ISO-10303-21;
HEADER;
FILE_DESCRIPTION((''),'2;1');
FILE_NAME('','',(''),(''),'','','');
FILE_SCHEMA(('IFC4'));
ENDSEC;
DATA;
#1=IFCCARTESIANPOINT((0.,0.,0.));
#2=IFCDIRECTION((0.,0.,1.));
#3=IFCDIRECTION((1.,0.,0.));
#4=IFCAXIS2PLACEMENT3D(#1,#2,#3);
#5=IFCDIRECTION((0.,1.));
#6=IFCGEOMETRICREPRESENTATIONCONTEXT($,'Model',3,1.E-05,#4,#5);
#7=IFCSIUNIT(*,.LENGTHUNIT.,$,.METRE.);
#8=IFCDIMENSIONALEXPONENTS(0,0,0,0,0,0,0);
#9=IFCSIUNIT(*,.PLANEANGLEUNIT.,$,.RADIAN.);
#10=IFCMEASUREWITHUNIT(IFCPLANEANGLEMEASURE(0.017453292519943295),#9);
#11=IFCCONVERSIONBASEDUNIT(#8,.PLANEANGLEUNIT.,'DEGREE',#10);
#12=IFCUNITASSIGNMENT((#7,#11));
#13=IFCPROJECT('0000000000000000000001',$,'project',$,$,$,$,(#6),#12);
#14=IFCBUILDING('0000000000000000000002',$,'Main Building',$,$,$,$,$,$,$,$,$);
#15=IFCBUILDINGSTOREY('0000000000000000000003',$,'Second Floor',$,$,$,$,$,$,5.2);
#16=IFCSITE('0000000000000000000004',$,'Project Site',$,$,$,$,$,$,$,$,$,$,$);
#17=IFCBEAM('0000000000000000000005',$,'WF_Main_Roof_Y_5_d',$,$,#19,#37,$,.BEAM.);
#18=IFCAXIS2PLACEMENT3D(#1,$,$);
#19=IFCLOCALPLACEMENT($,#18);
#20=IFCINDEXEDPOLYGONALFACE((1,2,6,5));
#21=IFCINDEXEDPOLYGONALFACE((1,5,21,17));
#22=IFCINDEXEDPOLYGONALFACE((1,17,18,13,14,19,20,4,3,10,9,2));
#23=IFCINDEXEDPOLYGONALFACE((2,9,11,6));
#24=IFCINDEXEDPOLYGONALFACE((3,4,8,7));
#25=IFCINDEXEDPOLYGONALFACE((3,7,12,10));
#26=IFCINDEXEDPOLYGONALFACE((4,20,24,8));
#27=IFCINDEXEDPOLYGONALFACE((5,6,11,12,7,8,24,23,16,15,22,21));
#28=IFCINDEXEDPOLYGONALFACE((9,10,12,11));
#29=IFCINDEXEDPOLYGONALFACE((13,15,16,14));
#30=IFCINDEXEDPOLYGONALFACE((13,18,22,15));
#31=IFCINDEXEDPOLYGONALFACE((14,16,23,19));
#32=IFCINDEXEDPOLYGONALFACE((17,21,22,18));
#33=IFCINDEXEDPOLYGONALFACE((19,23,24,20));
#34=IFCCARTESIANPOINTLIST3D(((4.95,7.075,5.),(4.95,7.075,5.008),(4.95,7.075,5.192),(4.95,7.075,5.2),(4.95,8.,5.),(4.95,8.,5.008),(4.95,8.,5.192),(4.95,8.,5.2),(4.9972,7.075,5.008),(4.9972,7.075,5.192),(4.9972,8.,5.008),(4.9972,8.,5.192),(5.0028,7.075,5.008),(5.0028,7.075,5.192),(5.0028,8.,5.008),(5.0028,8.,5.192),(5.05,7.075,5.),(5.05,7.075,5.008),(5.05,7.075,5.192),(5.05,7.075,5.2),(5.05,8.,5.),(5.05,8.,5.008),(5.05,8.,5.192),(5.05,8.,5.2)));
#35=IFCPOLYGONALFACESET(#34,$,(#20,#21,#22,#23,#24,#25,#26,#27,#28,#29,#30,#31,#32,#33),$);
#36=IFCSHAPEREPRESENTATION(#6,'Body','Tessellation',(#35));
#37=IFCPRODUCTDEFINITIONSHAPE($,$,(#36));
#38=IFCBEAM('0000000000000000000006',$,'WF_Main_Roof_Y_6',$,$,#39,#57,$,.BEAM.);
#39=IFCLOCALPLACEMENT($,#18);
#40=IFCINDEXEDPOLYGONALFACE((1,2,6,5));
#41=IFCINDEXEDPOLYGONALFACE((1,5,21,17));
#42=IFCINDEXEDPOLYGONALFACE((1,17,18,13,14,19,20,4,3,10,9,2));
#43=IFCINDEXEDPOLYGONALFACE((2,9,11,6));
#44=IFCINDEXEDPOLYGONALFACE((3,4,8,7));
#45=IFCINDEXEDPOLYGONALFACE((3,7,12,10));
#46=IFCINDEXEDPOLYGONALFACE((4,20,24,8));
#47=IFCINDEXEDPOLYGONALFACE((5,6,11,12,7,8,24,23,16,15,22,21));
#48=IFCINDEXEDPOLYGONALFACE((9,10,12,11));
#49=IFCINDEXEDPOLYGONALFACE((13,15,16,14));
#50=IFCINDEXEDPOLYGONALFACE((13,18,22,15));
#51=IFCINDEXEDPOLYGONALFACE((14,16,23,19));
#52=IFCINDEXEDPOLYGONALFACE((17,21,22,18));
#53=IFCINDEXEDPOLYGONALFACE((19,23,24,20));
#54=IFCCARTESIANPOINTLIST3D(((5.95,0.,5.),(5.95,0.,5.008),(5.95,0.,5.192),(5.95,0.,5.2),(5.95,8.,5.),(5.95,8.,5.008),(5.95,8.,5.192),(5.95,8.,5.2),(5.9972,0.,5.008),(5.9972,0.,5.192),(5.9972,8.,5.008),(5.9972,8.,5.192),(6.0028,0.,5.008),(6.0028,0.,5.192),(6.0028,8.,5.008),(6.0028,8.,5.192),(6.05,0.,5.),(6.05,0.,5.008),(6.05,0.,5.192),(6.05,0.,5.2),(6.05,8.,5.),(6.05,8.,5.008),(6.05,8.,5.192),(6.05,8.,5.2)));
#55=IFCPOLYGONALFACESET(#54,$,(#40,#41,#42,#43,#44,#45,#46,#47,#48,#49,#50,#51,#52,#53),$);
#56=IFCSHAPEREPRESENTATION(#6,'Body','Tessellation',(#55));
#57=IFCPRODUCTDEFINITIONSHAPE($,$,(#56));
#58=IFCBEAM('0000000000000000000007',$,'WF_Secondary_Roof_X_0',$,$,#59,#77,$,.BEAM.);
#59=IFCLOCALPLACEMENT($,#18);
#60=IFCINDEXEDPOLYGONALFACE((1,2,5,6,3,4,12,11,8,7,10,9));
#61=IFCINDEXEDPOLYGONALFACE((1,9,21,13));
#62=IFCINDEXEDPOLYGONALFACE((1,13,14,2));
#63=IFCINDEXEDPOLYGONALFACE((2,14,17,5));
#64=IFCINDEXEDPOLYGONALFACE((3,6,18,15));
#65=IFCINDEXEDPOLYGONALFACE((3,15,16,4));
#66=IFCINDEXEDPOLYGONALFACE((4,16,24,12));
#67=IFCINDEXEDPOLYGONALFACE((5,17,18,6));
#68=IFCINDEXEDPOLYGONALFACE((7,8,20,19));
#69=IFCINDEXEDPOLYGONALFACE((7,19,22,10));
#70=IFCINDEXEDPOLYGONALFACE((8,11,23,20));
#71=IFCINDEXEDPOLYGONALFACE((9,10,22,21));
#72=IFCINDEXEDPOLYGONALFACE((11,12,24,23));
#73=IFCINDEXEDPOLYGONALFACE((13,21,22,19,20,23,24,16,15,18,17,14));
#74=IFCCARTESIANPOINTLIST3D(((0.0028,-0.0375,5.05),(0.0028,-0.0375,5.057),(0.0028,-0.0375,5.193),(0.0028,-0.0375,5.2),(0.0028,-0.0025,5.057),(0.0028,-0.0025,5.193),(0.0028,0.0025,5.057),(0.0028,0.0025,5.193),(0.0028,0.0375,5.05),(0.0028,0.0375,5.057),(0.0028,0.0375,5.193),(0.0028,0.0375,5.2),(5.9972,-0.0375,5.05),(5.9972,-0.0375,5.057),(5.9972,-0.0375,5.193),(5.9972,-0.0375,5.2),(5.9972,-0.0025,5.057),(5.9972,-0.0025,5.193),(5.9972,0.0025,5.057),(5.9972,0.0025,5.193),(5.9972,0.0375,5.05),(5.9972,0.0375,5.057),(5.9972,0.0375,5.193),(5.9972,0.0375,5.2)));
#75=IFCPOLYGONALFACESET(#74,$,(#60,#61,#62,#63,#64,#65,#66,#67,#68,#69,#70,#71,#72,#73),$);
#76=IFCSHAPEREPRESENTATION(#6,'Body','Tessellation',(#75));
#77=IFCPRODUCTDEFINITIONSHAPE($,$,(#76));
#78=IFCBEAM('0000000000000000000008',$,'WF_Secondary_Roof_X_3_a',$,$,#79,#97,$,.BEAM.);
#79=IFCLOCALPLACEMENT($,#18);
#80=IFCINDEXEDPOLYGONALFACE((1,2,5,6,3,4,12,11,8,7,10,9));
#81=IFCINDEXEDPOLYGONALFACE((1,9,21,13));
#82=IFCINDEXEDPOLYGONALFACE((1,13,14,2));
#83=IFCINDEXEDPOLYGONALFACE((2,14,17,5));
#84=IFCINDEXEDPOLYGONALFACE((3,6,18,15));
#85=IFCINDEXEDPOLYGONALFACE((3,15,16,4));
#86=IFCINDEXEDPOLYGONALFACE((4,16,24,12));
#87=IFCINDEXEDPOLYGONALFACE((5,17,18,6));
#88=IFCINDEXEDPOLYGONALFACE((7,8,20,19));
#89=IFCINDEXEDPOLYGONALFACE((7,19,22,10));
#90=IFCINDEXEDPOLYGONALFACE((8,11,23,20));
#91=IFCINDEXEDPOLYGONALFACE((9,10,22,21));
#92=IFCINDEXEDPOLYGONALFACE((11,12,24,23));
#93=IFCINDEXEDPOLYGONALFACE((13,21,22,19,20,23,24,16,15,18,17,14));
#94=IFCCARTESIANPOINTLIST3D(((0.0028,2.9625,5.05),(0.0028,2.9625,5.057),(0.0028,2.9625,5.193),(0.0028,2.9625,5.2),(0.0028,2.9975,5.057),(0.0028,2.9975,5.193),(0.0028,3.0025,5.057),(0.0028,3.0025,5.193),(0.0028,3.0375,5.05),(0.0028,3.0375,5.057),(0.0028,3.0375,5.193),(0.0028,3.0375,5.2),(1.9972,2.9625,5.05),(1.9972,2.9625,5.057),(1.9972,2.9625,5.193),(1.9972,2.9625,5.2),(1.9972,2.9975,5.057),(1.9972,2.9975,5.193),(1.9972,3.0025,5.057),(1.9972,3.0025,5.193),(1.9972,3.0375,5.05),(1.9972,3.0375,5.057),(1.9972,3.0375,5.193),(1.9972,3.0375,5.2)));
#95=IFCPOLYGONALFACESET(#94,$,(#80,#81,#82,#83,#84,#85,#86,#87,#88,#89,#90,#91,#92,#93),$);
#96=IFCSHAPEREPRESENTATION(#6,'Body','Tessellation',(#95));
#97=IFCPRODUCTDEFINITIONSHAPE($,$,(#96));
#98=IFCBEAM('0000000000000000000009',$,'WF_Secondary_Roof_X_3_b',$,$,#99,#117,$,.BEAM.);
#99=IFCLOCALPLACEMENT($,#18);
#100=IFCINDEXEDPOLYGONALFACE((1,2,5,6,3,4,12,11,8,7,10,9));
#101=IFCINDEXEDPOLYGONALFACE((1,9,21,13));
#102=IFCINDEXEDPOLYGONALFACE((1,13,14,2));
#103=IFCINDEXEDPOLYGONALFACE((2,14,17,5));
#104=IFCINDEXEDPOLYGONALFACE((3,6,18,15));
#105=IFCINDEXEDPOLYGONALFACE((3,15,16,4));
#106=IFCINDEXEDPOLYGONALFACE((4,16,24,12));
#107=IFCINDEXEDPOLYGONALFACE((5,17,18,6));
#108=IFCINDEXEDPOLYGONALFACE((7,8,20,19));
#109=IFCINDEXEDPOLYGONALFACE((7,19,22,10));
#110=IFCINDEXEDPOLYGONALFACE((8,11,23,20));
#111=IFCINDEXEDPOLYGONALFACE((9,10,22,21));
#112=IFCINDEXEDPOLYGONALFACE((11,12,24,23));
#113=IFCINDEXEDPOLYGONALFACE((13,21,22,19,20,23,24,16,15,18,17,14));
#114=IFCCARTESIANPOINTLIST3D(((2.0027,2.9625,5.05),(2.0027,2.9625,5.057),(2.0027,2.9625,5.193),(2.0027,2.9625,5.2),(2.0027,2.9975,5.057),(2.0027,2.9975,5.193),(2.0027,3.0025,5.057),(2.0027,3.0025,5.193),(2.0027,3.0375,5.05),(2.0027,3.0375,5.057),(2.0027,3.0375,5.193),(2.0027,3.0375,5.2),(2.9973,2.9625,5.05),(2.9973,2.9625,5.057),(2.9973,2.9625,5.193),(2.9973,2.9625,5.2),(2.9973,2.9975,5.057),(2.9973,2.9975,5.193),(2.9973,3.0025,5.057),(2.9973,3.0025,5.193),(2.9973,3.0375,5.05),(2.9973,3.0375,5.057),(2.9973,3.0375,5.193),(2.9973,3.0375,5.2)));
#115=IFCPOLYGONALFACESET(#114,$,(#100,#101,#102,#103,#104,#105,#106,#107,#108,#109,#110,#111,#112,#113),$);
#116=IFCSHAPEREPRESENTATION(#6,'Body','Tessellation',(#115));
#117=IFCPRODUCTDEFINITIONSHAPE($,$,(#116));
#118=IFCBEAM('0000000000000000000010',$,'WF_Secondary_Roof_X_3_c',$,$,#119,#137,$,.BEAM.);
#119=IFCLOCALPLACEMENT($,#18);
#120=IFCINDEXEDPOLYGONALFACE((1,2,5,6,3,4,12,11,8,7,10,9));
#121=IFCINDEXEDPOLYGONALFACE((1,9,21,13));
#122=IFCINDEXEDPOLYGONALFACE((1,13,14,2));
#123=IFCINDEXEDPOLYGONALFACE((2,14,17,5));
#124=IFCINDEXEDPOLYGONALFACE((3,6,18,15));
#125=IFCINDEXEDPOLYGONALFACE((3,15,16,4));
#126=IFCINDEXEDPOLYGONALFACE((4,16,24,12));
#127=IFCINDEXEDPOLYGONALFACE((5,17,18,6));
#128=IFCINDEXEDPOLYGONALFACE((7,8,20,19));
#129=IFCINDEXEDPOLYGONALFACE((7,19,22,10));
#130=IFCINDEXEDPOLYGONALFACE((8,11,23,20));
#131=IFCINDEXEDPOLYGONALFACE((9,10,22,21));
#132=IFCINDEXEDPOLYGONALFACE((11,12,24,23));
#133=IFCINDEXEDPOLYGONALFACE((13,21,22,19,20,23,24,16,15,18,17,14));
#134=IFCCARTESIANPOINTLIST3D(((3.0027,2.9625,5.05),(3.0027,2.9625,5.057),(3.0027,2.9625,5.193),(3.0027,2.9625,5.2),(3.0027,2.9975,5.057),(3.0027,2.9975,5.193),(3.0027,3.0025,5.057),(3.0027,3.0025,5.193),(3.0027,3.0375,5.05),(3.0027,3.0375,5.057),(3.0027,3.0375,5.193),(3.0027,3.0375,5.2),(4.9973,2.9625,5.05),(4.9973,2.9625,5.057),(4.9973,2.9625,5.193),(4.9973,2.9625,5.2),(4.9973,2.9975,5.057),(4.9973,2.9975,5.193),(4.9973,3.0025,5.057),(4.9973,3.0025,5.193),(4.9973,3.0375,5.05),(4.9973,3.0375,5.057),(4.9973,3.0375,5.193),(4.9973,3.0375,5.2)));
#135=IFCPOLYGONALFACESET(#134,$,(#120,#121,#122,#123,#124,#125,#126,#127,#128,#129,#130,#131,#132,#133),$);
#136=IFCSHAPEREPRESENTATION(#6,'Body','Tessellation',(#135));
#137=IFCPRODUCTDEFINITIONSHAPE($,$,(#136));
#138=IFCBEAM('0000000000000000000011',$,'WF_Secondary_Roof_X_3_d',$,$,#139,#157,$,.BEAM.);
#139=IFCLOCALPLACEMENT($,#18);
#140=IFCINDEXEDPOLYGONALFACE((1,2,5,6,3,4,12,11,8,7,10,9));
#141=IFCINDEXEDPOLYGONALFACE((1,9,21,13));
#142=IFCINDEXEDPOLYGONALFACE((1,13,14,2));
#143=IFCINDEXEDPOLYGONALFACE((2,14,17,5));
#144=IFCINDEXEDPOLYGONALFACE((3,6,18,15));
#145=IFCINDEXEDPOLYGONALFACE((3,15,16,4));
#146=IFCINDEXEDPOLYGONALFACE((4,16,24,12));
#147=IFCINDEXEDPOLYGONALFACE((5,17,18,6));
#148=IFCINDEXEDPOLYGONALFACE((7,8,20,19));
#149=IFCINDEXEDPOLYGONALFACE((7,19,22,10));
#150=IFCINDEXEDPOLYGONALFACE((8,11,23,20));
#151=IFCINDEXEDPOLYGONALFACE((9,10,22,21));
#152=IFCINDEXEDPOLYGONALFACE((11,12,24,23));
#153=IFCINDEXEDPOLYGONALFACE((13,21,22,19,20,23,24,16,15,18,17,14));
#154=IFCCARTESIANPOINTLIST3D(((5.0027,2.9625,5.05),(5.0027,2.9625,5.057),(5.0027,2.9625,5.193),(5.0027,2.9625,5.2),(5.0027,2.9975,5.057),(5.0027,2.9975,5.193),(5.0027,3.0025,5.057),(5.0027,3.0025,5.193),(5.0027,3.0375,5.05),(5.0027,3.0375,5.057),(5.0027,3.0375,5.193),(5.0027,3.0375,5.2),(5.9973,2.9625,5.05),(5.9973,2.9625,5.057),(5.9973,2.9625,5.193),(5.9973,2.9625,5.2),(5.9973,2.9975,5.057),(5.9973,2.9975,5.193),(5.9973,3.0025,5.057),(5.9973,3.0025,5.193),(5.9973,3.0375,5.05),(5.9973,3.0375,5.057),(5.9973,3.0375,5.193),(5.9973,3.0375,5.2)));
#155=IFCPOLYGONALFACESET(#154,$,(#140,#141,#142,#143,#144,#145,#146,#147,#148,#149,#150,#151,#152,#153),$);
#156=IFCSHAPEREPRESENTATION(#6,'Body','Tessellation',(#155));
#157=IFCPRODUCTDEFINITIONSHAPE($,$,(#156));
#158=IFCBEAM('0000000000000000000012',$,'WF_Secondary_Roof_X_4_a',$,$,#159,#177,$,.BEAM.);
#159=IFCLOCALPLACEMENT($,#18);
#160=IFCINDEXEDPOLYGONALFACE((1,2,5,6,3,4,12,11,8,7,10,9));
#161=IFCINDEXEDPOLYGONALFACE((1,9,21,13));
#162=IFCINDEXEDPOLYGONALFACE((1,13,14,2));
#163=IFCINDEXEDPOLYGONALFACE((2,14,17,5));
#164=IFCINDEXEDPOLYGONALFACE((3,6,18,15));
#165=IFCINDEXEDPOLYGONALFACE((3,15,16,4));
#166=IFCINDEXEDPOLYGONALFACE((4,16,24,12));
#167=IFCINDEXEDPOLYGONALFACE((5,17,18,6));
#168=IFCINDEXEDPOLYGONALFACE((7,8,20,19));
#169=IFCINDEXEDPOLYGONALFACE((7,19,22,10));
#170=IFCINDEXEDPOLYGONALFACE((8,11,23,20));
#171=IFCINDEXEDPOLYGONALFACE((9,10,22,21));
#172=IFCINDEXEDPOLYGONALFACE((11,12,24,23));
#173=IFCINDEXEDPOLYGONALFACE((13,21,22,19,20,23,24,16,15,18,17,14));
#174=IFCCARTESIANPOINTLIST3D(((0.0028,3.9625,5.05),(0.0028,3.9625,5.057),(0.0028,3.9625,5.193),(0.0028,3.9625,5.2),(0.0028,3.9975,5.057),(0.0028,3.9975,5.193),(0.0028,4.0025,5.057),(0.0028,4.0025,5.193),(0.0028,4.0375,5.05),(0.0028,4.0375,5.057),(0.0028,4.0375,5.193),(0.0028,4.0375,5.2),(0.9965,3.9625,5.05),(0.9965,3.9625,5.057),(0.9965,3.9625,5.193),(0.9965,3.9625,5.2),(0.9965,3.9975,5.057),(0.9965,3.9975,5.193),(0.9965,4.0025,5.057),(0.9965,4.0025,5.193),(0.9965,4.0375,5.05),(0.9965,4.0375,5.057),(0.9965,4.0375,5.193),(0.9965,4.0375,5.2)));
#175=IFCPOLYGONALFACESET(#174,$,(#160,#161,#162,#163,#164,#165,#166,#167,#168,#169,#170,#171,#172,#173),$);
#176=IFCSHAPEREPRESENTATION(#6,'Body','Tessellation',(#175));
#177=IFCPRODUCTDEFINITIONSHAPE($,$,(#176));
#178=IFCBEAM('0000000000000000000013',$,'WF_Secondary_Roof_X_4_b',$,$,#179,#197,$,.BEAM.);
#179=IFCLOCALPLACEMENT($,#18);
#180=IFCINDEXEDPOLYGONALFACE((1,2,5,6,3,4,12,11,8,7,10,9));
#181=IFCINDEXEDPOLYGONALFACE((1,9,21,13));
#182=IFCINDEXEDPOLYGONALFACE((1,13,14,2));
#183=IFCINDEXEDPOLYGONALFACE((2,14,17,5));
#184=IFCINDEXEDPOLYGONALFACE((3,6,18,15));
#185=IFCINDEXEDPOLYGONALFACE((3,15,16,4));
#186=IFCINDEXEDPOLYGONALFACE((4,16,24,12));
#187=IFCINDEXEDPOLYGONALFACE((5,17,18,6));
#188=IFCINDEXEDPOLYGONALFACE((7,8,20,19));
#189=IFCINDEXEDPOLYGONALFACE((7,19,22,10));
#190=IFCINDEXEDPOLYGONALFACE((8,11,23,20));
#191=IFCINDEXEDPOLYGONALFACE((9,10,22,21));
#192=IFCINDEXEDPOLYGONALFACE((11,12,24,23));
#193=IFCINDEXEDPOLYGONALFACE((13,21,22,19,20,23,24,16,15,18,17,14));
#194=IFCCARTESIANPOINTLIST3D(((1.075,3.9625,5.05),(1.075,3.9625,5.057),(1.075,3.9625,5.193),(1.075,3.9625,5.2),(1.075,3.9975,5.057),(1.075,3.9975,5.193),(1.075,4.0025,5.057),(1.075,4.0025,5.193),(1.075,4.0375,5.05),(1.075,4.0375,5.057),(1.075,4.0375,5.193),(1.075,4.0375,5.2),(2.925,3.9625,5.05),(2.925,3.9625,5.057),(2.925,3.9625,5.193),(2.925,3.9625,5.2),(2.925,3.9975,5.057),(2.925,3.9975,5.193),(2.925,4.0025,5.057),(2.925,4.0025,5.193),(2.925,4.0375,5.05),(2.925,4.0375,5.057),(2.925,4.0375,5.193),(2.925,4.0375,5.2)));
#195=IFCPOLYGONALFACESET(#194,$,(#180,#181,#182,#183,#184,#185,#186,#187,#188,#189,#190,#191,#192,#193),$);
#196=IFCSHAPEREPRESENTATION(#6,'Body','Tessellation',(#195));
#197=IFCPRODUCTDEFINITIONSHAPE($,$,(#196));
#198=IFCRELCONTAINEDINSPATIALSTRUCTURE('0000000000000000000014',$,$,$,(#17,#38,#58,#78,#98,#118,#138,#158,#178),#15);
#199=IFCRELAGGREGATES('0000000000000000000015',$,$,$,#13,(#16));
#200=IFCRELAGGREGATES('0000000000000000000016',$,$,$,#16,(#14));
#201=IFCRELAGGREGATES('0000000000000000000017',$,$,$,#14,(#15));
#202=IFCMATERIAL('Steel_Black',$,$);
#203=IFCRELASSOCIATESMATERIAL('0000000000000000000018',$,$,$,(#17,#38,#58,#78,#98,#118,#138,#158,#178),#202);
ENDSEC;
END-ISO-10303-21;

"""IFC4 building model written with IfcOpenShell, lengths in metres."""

from ifc_helpers import new_model, entity, si_unit, converted_unit, direction, frame, frame_2d, origin_with_axes, place, context, project, spatial, i_section, extrude, material, element, save


model = new_model("IFC4")

# Units and contexts
model_context = context("Model", 3, precision=1e-05, world=origin_with_axes(), true_north=direction((0.0, 1.0)))
ifc_project = project(units=[si_unit("LENGTHUNIT", "METRE"), converted_unit("PLANEANGLEUNIT", "DEGREE", entity("IfcPlaneAngleMeasure", 0.017453292519943295), si_unit("PLANEANGLEUNIT", "RADIAN"), dimensions=[0, 0, 0, 0, 0, 0, 0])], contexts=[model_context])

# Site, building, storey
site = spatial("IfcSite", under=ifc_project, Name="Project Site")
building = spatial("IfcBuilding", under=site, Name="Main Building")
storey = spatial("IfcBuildingStorey", under=building, Name="Second Floor", Elevation=5.2)

# Beams
ifc_material = material(Name="Steel_Black")
beam_1_placement = place(None, frame((5.0, 7.075, 5.0), z_axis=(0.0, 0.0, 1.0), x_axis=(0.0, 1.0, 0.0)))
element("IfcBeam", 1, at=beam_1_placement, inside=storey, material=ifc_material, Name="WF_Main_Roof_Y_5_d", PredefinedType="BEAM", context=model_context, shape_type="SweptSolid", body=[
    extrude(i_section(OverallWidth=0.1, OverallDepth=0.2, WebThickness=0.0055, FlangeThickness=0.008, at=frame_2d((0.0, 0.1))), frame((0.0, 0.0, 0.0), z_axis=(1.0, 0.0, 0.0), x_axis=(0.0, 1.0, 0.0)), (0.0, 0.0, 1.0), 0.925),
])
beam_2_placement = place(None, frame((6.0, 0.0, 5.0), z_axis=(0.0, 0.0, 1.0), x_axis=(0.0, 1.0, 0.0)))
element("IfcBeam", 2, at=beam_2_placement, inside=storey, material=ifc_material, Name="WF_Main_Roof_Y_6", PredefinedType="BEAM", context=model_context, shape_type="SweptSolid", body=[
    extrude(i_section(OverallWidth=0.1, OverallDepth=0.2, WebThickness=0.0055, FlangeThickness=0.008, at=frame_2d((0.0, 0.1))), frame((0.0, 0.0, 0.0), z_axis=(1.0, 0.0, 0.0), x_axis=(0.0, 1.0, 0.0)), (0.0, 0.0, 1.0), 8.0),
])
beam_3_placement = place(None, frame((0.0027, 0.0, 5.05), z_axis=(0.0, 0.0, 1.0), x_axis=(1.0, 0.0, 0.0)))
element("IfcBeam", 3, at=beam_3_placement, inside=storey, material=ifc_material, Name="WF_Secondary_Roof_X_0", PredefinedType="BEAM", context=model_context, shape_type="SweptSolid", body=[
    extrude(i_section(OverallWidth=0.075, OverallDepth=0.15, WebThickness=0.005, FlangeThickness=0.007, at=frame_2d((0.0, 0.075))), frame((0.0, 0.0, 0.0), z_axis=(1.0, 0.0, 0.0), x_axis=(0.0, 1.0, 0.0)), (0.0, 0.0, 1.0), 5.9945),
])
beam_4_placement = place(None, frame((0.0027, 3.0, 5.05), z_axis=(0.0, 0.0, 1.0), x_axis=(1.0, 0.0, 0.0)))
element("IfcBeam", 4, at=beam_4_placement, inside=storey, material=ifc_material, Name="WF_Secondary_Roof_X_3_a", PredefinedType="BEAM", context=model_context, shape_type="SweptSolid", body=[
    extrude(i_section(OverallWidth=0.075, OverallDepth=0.15, WebThickness=0.005, FlangeThickness=0.007, at=frame_2d((0.0, 0.075))), frame((0.0, 0.0, 0.0), z_axis=(1.0, 0.0, 0.0), x_axis=(0.0, 1.0, 0.0)), (0.0, 0.0, 1.0), 1.9945),
])
beam_5_placement = place(None, frame((2.0027, 3.0, 5.05), z_axis=(0.0, 0.0, 1.0), x_axis=(1.0, 0.0, 0.0)))
element("IfcBeam", 5, at=beam_5_placement, inside=storey, material=ifc_material, Name="WF_Secondary_Roof_X_3_b", PredefinedType="BEAM", context=model_context, shape_type="SweptSolid", body=[
    extrude(i_section(OverallWidth=0.075, OverallDepth=0.15, WebThickness=0.005, FlangeThickness=0.007, at=frame_2d((0.0, 0.075))), frame((0.0, 0.0, 0.0), z_axis=(1.0, 0.0, 0.0), x_axis=(0.0, 1.0, 0.0)), (0.0, 0.0, 1.0), 0.9946),
])
beam_6_placement = place(None, frame((3.0027, 3.0, 5.05), z_axis=(0.0, 0.0, 1.0), x_axis=(1.0, 0.0, 0.0)))
element("IfcBeam", 6, at=beam_6_placement, inside=storey, material=ifc_material, Name="WF_Secondary_Roof_X_3_c", PredefinedType="BEAM", context=model_context, shape_type="SweptSolid", body=[
    extrude(i_section(OverallWidth=0.075, OverallDepth=0.15, WebThickness=0.005, FlangeThickness=0.007, at=frame_2d((0.0, 0.075))), frame((0.0, 0.0, 0.0), z_axis=(1.0, 0.0, 0.0), x_axis=(0.0, 1.0, 0.0)), (0.0, 0.0, 1.0), 1.9946),
])
beam_7_placement = place(None, frame((5.0027, 3.0, 5.05), z_axis=(0.0, 0.0, 1.0), x_axis=(1.0, 0.0, 0.0)))
element("IfcBeam", 7, at=beam_7_placement, inside=storey, material=ifc_material, Name="WF_Secondary_Roof_X_3_d", PredefinedType="BEAM", context=model_context, shape_type="SweptSolid", body=[
    extrude(i_section(OverallWidth=0.075, OverallDepth=0.15, WebThickness=0.005, FlangeThickness=0.007, at=frame_2d((0.0, 0.075))), frame((0.0, 0.0, 0.0), z_axis=(1.0, 0.0, 0.0), x_axis=(0.0, 1.0, 0.0)), (0.0, 0.0, 1.0), 0.9946),
])
beam_8_placement = place(None, frame((0.0027, 4.0, 5.05), z_axis=(0.0, 0.0, 1.0), x_axis=(1.0, 0.0, 0.0)))
element("IfcBeam", 8, at=beam_8_placement, inside=storey, material=ifc_material, Name="WF_Secondary_Roof_X_4_a", PredefinedType="BEAM", context=model_context, shape_type="SweptSolid", body=[
    extrude(i_section(OverallWidth=0.075, OverallDepth=0.15, WebThickness=0.005, FlangeThickness=0.007, at=frame_2d((0.0, 0.075))), frame((0.0, 0.0, 0.0), z_axis=(1.0, 0.0, 0.0), x_axis=(0.0, 1.0, 0.0)), (0.0, 0.0, 1.0), 0.9938),
])
for number, where, z_axis, x_axis, name in (
    (9, (1.075, 4.0, 5.05), (0.0, 0.0, 1.0), (1.0, 0.0, 0.0), "WF_Secondary_Roof_X_4_b"),
):
    element("IfcBeam", number, at=place(None, frame(where, z_axis=z_axis, x_axis=x_axis)), inside=storey, material=ifc_material, Name=name, PredefinedType="BEAM", context=model_context, shape_type="SweptSolid", body=[
        extrude(i_section(OverallWidth=0.075, OverallDepth=0.15, WebThickness=0.005, FlangeThickness=0.007, at=frame_2d((0.0, 0.075))), frame((0.0, 0.0, 0.0), z_axis=(1.0, 0.0, 0.0), x_axis=(0.0, 1.0, 0.0)), (0.0, 0.0, 1.0), 1.85),
    ])

save(model, "model.ifc")
